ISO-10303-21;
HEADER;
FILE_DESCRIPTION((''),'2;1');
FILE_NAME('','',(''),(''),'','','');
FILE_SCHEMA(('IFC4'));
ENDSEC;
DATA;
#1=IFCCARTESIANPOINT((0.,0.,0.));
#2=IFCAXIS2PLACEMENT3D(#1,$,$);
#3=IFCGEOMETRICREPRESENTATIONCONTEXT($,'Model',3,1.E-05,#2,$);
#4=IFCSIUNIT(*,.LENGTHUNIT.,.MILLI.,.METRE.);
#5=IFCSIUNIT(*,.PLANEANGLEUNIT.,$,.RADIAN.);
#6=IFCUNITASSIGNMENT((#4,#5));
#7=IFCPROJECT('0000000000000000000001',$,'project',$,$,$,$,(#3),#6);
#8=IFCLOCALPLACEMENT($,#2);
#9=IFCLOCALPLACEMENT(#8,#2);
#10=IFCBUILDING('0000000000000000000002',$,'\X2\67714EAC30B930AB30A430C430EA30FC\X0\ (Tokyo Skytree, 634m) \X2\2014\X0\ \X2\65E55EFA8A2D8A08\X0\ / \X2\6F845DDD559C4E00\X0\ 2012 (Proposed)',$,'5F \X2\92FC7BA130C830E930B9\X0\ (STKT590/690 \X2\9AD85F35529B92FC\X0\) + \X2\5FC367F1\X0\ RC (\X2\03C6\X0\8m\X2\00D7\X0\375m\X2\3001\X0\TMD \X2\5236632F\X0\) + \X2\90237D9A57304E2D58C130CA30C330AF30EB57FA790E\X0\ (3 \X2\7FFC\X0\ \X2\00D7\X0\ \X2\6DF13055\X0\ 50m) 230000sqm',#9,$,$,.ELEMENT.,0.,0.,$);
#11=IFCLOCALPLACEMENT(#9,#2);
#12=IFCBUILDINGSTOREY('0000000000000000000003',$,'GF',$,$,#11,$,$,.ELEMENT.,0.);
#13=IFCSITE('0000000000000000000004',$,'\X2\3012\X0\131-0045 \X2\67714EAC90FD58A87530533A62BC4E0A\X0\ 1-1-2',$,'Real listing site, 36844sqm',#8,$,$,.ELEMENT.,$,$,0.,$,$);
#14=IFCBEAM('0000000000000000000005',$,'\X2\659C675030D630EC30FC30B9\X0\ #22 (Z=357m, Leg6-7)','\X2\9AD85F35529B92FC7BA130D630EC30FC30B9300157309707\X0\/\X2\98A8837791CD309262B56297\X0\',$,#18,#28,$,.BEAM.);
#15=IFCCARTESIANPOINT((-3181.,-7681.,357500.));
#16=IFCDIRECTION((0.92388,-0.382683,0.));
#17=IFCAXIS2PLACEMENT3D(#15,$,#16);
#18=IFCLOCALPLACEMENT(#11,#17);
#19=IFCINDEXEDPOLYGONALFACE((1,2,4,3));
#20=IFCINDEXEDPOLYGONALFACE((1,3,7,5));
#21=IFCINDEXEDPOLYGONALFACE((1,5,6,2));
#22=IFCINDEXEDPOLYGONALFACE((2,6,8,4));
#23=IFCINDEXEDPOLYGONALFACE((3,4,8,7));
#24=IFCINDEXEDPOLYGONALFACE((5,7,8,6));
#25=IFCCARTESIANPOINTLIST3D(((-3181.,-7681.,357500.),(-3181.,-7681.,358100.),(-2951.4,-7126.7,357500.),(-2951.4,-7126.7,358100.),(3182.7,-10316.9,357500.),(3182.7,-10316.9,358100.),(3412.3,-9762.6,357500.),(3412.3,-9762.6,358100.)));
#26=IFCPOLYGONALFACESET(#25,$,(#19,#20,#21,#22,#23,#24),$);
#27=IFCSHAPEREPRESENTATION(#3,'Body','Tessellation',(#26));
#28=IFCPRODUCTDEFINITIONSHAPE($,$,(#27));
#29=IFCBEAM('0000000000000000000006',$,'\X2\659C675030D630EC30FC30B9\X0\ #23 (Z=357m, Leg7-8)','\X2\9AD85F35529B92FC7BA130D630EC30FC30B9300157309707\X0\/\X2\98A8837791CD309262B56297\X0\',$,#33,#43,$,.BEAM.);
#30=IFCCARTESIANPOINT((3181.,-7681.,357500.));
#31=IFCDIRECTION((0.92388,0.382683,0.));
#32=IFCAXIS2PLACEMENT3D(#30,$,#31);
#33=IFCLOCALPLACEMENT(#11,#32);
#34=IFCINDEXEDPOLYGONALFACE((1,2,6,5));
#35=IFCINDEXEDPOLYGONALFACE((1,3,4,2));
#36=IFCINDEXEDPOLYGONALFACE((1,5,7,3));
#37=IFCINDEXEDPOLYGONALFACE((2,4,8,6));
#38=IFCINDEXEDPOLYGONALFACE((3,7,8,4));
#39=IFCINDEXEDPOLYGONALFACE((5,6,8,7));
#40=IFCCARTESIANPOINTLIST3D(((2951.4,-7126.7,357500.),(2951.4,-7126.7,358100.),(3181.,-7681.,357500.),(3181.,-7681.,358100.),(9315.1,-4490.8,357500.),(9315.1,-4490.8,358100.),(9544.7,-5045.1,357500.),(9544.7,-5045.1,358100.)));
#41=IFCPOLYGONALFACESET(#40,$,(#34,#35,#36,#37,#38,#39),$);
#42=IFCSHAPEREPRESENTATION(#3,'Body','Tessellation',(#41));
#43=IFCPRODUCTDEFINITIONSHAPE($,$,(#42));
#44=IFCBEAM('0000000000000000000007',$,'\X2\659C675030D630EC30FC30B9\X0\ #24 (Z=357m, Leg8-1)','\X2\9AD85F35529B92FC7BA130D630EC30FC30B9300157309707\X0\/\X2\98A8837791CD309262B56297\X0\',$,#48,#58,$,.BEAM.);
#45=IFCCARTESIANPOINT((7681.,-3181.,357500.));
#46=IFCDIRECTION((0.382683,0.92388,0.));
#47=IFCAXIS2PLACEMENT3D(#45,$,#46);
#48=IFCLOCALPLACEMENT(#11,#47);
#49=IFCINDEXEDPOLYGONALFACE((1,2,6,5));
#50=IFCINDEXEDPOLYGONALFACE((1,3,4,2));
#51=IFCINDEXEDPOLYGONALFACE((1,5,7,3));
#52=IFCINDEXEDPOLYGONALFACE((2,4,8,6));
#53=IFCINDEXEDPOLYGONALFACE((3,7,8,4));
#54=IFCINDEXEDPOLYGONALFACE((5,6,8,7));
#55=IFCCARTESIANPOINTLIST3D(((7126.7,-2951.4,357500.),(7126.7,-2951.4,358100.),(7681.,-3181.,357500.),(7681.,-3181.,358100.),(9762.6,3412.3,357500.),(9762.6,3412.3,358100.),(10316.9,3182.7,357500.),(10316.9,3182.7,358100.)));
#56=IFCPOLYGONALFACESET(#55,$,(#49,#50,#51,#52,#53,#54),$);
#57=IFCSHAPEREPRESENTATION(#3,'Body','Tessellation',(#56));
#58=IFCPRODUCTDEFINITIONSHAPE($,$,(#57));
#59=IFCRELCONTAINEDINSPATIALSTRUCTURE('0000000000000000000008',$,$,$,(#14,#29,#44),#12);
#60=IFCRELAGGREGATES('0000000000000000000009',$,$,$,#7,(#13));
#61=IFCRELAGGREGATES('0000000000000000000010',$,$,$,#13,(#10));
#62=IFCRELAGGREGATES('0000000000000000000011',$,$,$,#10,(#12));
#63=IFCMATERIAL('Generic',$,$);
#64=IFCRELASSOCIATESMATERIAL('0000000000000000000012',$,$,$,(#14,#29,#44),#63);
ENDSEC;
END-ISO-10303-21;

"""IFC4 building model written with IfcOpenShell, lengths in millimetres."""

from ifc_helpers import new_model, si_unit, frame, frame_2d, origin, place, context, project, spatial, rectangle, extrude, material, element, save


model = new_model("IFC4")

# Units and contexts
model_context = context("Model", 3, precision=1e-05, world=origin())
ifc_project = project(units=[si_unit("LENGTHUNIT", "METRE", prefix="MILLI"), si_unit("PLANEANGLEUNIT", "RADIAN")], contexts=[model_context])

# Site, building, storey
site_placement = place(None, origin())
site = spatial("IfcSite", under=ifc_project, at=site_placement, Name="〒131-0045 東京都墨田区押上 1-1-2", ObjectType="Real listing site, 36844sqm", CompositionType="ELEMENT", RefElevation=0.0)
building_placement = place(site_placement, origin())
building = spatial("IfcBuilding", under=site, at=building_placement, Name="東京スカイツリー (Tokyo Skytree, 634m) — 日建設計 / 澄川喜一 2012 (Proposed)", ObjectType="5F 鋼管トラス (STKT590/690 高張力鋼) + 心柱 RC (φ8m×375m、TMD 制振) + 連続地中壁ナックル基礎 (3 翼 × 深さ 50m) 230000sqm", CompositionType="ELEMENT", ElevationOfRefHeight=0.0, ElevationOfTerrain=0.0)
storey_placement = place(building_placement, origin())
storey = spatial("IfcBuildingStorey", under=building, at=storey_placement, Name="GF", CompositionType="ELEMENT", Elevation=0.0)

# Shared definitions
ifc_material_1 = material(Name="Generic")

# Beams
beam_1_placement = place(storey_placement, frame((-3181.0, -7681.0, 357500.0), x_axis=(0.92388, -0.382683, 0.0)))
element("IfcBeam", 1, at=beam_1_placement, inside=storey, material=ifc_material_1, Name="斜材ブレース #22 (Z=357m, Leg6-7)", Description="高張力鋼管ブレース、地震/風荷重を抵抗", PredefinedType="BEAM", context=model_context, shape_type="SweptSolid", body=[
    extrude(rectangle(XDim=6888.0, YDim=600.0, at=frame_2d((3444.0, 300.0))), frame((-3181.0, -7681.0, 357500.0), x_axis=(0.92388, -0.382683, 0.0)), (0.0, 0.0, 1.0), 600.0),
])
beam_2_placement = place(storey_placement, frame((3181.0, -7681.0, 357500.0), x_axis=(0.92388, 0.382683, 0.0)))
element("IfcBeam", 2, at=beam_2_placement, inside=storey, material=ifc_material_1, Name="斜材ブレース #23 (Z=357m, Leg7-8)", Description="高張力鋼管ブレース、地震/風荷重を抵抗", PredefinedType="BEAM", context=model_context, shape_type="SweptSolid", body=[
    extrude(rectangle(XDim=6888.0, YDim=600.0, at=frame_2d((3444.0, 300.0))), frame((3181.0, -7681.0, 357500.0), x_axis=(0.92388, 0.382683, 0.0)), (0.0, 0.0, 1.0), 600.0),
])
beam_3_placement = place(storey_placement, frame((7681.0, -3181.0, 357500.0), x_axis=(0.382683, 0.92388, 0.0)))
element("IfcBeam", 3, at=beam_3_placement, inside=storey, material=ifc_material_1, Name="斜材ブレース #24 (Z=357m, Leg8-1)", Description="高張力鋼管ブレース、地震/風荷重を抵抗", PredefinedType="BEAM", context=model_context, shape_type="SweptSolid", body=[
    extrude(rectangle(XDim=6888.0, YDim=600.0, at=frame_2d((3444.0, 300.0))), frame((7681.0, -3181.0, 357500.0), x_axis=(0.382683, 0.92388, 0.0)), (0.0, 0.0, 1.0), 600.0),
])

save(model, "model.ifc")
